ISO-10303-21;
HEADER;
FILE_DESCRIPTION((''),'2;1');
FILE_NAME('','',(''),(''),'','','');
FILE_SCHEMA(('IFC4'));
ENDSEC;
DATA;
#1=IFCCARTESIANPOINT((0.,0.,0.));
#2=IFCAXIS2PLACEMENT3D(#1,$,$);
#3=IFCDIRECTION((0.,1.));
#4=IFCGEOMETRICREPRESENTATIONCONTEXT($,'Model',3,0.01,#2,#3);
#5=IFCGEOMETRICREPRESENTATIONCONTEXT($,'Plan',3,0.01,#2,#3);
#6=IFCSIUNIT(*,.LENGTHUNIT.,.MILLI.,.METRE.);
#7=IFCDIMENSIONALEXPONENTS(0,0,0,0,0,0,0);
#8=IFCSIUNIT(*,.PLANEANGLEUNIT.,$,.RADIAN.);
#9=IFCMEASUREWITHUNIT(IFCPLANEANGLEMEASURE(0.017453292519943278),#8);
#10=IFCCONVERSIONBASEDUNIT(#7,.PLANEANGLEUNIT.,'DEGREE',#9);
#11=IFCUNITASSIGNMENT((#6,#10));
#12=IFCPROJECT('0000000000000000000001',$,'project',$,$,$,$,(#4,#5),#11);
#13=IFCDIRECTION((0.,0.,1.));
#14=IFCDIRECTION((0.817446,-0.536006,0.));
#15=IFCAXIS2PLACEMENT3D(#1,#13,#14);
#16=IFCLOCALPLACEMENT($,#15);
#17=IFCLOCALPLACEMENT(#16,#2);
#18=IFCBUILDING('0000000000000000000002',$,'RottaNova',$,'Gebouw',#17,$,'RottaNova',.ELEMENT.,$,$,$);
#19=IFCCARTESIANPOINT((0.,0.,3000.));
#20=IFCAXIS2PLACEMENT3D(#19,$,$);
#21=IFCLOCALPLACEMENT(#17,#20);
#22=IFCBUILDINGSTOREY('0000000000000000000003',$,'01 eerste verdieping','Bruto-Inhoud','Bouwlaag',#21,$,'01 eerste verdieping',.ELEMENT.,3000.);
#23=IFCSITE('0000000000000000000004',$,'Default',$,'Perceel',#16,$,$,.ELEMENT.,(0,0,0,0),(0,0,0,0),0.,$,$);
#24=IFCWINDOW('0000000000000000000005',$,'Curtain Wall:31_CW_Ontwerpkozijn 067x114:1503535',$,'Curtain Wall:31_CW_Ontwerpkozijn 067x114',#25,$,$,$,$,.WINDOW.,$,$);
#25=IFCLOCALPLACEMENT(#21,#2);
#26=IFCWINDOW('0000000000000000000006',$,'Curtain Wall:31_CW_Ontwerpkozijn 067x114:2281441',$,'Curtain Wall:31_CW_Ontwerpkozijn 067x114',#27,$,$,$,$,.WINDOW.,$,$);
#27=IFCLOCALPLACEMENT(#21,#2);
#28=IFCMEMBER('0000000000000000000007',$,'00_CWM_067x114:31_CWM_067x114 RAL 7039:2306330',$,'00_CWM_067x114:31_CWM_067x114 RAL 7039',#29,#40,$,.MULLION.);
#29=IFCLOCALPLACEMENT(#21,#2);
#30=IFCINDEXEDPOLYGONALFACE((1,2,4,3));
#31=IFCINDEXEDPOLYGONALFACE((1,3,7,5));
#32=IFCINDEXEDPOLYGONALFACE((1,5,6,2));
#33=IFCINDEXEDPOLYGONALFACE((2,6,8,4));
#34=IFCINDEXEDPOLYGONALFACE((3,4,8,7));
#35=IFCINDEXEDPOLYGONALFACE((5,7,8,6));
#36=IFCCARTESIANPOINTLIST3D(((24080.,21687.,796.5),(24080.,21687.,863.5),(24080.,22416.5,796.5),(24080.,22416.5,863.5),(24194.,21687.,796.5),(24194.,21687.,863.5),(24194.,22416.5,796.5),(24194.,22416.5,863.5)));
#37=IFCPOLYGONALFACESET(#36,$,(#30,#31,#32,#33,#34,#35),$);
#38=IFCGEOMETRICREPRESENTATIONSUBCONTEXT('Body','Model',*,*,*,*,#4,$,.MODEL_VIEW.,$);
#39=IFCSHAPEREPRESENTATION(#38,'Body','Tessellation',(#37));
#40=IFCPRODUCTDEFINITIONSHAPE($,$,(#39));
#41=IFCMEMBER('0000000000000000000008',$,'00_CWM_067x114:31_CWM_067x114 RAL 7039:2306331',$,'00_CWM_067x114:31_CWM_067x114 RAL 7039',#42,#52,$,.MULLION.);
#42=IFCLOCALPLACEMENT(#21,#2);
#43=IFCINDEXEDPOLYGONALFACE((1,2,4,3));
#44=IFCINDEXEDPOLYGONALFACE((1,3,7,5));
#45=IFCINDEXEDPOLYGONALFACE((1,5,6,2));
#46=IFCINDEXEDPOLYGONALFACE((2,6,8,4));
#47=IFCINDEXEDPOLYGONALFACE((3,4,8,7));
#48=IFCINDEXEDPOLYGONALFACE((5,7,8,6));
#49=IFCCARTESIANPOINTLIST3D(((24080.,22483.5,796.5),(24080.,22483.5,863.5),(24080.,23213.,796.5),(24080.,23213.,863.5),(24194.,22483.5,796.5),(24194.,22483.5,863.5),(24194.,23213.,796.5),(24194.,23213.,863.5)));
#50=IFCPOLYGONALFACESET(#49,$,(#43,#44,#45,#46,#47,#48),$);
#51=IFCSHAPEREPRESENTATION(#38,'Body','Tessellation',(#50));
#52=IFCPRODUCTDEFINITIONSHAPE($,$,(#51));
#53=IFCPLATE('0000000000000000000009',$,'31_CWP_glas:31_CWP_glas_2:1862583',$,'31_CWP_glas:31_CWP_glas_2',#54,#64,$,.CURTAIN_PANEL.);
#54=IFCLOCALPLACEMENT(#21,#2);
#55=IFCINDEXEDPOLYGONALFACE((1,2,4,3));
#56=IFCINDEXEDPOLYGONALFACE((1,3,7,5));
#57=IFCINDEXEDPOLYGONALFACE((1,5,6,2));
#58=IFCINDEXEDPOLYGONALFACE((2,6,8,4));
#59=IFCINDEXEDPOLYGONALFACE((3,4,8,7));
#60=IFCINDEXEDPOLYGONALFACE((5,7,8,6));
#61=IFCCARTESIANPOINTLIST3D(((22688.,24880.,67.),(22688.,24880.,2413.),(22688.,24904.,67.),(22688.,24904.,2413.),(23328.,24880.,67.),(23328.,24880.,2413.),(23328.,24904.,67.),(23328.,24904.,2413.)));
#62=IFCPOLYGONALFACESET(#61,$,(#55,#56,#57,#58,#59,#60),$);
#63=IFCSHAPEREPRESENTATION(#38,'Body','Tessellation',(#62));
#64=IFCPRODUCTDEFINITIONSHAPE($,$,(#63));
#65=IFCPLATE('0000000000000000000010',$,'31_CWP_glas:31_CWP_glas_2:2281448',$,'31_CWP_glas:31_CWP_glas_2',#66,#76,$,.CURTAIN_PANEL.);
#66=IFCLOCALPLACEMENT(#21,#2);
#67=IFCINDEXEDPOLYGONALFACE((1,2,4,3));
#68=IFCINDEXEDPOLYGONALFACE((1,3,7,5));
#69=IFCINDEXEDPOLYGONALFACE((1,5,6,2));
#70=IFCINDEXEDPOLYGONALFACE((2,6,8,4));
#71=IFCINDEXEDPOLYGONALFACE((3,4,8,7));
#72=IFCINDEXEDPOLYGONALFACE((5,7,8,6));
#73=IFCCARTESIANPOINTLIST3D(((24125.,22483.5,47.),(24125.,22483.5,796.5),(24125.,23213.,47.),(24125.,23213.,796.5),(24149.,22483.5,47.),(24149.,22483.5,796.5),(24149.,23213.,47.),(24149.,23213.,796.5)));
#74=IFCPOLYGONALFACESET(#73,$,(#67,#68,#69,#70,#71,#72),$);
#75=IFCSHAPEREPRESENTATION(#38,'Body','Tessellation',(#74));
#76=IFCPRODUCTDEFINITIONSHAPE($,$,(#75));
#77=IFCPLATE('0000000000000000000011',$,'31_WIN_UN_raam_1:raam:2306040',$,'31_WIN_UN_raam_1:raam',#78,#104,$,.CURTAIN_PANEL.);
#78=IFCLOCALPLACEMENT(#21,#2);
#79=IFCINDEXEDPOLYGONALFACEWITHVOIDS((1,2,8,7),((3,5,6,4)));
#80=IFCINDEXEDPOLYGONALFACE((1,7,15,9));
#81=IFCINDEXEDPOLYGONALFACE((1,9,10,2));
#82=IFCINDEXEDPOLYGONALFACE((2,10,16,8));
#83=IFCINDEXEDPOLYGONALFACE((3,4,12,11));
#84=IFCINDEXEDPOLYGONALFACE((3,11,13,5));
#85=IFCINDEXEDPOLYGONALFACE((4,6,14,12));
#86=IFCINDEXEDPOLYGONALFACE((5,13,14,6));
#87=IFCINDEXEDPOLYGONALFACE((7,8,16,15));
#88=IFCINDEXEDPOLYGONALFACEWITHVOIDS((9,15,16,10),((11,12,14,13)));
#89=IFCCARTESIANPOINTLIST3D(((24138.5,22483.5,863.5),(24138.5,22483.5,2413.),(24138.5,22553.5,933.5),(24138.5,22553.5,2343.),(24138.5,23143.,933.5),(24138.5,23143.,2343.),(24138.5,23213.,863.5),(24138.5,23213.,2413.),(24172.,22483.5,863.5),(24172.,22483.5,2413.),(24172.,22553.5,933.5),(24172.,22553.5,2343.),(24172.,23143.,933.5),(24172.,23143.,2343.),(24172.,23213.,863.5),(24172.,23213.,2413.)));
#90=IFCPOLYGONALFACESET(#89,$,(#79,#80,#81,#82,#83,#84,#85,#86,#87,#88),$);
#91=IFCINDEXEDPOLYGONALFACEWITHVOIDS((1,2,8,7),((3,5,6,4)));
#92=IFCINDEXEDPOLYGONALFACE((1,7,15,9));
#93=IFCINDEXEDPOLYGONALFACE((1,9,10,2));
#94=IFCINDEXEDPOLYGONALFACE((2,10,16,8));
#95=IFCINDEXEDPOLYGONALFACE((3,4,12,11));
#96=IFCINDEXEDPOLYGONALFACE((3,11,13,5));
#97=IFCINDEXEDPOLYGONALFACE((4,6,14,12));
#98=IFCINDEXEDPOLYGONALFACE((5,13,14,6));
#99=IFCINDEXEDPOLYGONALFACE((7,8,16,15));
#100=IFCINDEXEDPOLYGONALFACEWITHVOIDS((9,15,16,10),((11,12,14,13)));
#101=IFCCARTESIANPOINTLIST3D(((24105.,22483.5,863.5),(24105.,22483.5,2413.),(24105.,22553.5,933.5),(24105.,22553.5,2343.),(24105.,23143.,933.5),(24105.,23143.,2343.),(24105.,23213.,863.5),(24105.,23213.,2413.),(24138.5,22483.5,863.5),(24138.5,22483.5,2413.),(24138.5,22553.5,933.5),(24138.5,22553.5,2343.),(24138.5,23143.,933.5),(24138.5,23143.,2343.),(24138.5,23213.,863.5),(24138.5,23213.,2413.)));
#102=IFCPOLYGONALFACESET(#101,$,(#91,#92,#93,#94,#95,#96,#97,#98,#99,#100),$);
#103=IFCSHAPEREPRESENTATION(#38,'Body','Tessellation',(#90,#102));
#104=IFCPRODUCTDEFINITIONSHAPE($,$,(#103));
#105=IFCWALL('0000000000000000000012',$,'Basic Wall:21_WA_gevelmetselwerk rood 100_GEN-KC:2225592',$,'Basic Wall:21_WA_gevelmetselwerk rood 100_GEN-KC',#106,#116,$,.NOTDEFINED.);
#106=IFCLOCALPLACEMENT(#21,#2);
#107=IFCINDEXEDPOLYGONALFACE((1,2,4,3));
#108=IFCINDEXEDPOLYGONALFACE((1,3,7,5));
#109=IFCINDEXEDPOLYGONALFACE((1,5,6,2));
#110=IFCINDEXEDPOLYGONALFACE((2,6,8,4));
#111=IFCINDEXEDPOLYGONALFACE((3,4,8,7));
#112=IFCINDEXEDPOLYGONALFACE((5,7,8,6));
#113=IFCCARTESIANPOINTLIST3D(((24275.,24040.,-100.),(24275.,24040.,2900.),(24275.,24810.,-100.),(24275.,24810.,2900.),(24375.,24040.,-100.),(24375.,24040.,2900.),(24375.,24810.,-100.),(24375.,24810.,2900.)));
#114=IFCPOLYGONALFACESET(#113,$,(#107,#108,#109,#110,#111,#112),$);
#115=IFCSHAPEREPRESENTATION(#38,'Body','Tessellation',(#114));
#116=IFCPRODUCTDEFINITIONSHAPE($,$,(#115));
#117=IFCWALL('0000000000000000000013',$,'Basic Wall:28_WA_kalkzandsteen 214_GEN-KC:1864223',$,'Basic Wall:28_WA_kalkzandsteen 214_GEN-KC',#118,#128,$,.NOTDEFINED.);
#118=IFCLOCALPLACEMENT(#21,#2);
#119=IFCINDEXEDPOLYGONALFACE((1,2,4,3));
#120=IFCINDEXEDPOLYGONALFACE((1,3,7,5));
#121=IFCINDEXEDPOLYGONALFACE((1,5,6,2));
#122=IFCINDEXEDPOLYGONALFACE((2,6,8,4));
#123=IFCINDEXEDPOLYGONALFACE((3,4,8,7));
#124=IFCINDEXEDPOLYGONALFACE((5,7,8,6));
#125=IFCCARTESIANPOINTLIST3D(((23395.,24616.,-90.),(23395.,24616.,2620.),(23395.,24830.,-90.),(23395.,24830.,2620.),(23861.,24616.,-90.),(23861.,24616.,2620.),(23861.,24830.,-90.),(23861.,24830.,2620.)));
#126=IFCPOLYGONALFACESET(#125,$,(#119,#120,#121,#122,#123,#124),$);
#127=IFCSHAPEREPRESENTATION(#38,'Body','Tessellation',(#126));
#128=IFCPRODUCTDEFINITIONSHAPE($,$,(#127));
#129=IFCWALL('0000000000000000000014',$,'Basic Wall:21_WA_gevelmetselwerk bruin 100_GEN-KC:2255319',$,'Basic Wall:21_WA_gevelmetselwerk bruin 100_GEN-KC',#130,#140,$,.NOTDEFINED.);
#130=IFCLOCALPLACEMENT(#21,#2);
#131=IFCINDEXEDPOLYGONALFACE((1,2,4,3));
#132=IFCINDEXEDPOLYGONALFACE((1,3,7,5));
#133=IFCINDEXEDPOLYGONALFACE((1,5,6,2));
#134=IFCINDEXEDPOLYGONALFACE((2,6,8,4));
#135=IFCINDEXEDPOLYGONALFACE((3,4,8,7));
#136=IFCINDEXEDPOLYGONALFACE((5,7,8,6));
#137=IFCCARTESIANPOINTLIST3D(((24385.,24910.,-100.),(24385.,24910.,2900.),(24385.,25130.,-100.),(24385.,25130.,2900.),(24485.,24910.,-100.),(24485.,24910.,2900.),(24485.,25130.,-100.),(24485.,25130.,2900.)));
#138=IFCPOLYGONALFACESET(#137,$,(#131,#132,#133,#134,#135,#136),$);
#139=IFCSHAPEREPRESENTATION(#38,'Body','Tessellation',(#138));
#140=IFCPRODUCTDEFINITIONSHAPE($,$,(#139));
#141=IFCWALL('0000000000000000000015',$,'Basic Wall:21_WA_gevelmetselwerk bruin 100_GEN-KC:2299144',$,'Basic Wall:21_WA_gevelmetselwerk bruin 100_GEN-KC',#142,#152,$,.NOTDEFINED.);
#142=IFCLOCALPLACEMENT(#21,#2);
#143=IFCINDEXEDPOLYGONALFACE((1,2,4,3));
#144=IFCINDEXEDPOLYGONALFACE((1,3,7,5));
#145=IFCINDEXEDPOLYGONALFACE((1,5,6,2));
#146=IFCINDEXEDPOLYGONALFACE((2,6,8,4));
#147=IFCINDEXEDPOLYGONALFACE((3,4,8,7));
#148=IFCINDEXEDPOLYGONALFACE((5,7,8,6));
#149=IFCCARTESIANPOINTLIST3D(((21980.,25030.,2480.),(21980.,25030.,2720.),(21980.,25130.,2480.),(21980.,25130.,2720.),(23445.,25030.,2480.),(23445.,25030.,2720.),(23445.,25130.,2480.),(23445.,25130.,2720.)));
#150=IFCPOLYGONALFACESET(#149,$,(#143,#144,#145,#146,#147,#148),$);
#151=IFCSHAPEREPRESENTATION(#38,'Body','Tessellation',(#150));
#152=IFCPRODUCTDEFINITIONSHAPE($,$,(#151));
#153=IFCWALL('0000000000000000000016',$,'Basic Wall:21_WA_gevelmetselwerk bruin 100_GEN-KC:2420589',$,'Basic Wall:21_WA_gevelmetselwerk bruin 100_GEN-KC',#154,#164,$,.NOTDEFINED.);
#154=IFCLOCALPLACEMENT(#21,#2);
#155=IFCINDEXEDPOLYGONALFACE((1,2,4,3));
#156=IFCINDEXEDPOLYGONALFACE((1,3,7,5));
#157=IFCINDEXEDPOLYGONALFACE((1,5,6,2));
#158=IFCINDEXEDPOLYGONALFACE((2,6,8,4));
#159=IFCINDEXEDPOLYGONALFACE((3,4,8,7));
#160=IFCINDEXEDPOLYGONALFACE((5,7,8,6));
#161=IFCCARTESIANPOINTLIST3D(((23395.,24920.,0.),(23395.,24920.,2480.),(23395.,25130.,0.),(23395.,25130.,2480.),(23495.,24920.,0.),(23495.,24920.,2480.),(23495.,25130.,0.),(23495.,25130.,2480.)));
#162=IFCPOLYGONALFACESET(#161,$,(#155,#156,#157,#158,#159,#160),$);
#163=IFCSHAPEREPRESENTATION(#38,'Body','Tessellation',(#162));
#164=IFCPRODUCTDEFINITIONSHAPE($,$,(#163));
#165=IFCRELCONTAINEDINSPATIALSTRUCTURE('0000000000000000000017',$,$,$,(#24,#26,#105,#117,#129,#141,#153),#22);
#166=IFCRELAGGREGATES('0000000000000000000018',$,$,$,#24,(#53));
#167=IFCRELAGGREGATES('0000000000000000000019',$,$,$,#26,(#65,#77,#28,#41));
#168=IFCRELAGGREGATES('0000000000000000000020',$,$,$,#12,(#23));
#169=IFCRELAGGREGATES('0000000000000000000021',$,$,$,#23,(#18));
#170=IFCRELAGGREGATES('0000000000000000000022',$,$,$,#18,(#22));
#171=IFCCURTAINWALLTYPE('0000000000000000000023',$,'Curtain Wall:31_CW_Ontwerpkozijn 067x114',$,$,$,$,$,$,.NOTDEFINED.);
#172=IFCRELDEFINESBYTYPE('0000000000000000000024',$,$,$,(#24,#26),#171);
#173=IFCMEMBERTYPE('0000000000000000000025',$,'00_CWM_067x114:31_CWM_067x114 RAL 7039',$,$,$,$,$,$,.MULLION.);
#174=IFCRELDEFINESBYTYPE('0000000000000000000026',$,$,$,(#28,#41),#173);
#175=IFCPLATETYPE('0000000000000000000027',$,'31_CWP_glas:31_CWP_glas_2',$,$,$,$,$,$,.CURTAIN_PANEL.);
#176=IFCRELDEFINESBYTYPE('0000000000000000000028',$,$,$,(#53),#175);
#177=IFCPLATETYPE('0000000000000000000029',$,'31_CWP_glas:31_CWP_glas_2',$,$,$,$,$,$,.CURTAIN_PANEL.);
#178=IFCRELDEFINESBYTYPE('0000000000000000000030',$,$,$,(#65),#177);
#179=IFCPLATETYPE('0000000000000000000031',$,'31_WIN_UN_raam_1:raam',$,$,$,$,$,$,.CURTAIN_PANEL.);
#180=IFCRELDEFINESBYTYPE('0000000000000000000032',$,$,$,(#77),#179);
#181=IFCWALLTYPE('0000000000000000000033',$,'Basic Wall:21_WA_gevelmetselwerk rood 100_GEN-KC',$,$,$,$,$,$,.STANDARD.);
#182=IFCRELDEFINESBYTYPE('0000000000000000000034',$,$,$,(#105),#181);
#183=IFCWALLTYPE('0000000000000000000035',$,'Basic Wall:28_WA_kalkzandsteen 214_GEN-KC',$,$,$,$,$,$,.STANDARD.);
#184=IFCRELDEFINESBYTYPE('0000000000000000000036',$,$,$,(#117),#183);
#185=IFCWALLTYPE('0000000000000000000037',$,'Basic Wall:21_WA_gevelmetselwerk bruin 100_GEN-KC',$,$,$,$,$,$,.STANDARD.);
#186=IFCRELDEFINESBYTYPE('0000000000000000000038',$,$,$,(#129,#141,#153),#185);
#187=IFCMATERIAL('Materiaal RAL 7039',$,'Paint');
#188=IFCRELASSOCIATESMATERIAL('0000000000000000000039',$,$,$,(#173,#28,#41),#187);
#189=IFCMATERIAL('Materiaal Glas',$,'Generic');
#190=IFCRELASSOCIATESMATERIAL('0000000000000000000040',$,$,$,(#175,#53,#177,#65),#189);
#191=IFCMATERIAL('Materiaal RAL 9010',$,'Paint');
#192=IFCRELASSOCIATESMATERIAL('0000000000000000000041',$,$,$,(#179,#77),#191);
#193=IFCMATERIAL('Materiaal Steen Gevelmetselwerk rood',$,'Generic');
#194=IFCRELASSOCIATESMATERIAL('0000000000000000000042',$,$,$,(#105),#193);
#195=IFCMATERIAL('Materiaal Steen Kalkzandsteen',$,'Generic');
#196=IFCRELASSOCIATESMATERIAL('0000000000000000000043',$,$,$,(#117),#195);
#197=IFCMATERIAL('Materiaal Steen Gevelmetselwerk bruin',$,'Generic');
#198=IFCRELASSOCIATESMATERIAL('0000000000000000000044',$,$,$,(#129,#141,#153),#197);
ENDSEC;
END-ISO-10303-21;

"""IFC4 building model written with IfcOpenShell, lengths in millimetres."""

from ifc_helpers import new_model, entity, si_unit, converted_unit, direction, frame, origin, place, context, subcontext, project, spatial, indexed_curve, outline, extrude, source, transform, mapped, material, type_object, type_shapes, element, aggregate, save


model = new_model("IFC4")

# Units and contexts
model_context = context("Model", 3, precision=0.01, world=origin(), true_north=direction((0.0, 1.0)))
plan_context = context("Plan", 3, precision=0.01, world=origin(), true_north=direction((0.0, 1.0)))
body_context = subcontext(model_context, "Body", "Model", "MODEL_VIEW")
ifc_project = project(units=[si_unit("LENGTHUNIT", "METRE", prefix="MILLI"), converted_unit("PLANEANGLEUNIT", "DEGREE", entity("IfcPlaneAngleMeasure", 0.017453292519943278), si_unit("PLANEANGLEUNIT", "RADIAN"), dimensions=[0, 0, 0, 0, 0, 0, 0])], contexts=[model_context, plan_context])

# Site, building, storey
site_placement = place(None, frame((0.0, 0.0, 0.0), z_axis=(0.0, 0.0, 1.0), x_axis=(0.817446, -0.536006, 0.0)))
site = spatial("IfcSite", under=ifc_project, at=site_placement, Name="Default", ObjectType="Perceel", CompositionType="ELEMENT", RefLatitude=(0, 0, 0, 0), RefLongitude=(0, 0, 0, 0), RefElevation=0.0)
building_placement = place(site_placement, origin())
building = spatial("IfcBuilding", under=site, at=building_placement, Name="RottaNova", ObjectType="Gebouw", LongName="RottaNova", CompositionType="ELEMENT")
storey_placement = place(building_placement, frame((0.0, 0.0, 3000.0)))
storey = spatial("IfcBuildingStorey", under=building, at=storey_placement, Name="01 eerste verdieping", Description="Bruto-Inhoud", ObjectType="Bouwlaag", LongName="01 eerste verdieping", CompositionType="ELEMENT", Elevation=3000.0)

# Windows, members
curtain_wall_type = type_object("IfcCurtainWallType", Name="Curtain Wall:31_CW_Ontwerpkozijn 067x114", PredefinedType="NOTDEFINED")
window_1_placement = place(storey_placement, frame((0.0, 0.0, -3000.0)))
window_1 = element("IfcWindow", 1, at=window_1_placement, inside=storey, type_object=curtain_wall_type, Name="Curtain Wall:31_CW_Ontwerpkozijn 067x114:1503535", ObjectType="Curtain Wall:31_CW_Ontwerpkozijn 067x114", PredefinedType="WINDOW")
ifc_material_1 = material(Name="Materiaal RAL 7039", Category="Paint")
window_2_placement = place(storey_placement, frame((0.0, 0.0, -3000.0)))
window_2 = element("IfcWindow", 2, at=window_2_placement, inside=storey, type_object=curtain_wall_type, Name="Curtain Wall:31_CW_Ontwerpkozijn 067x114:2281441", ObjectType="Curtain Wall:31_CW_Ontwerpkozijn 067x114", PredefinedType="WINDOW")
member_type_1 = type_object("IfcMemberType", Name="00_CWM_067x114:31_CWM_067x114 RAL 7039", PredefinedType="MULLION", material=ifc_material_1)
shared_shape_1 = source(origin(), body_context, "Body", "SweptSolid", [
    extrude(outline(indexed_curve([(-33.5, -57.0), (33.5, -57.0), (33.5, 57.0), (-33.5, 57.0), (-33.5, -57.0)], self_intersect=False)), frame((0.0, 57.0, -729.5), z_axis=(0.0, 0.0, 1.0), x_axis=(-1.0, 0.0, 0.0)), (0.0, 0.0, 1.0), 729.5),
])
type_shapes(member_type_1, [shared_shape_1])
member_1_placement = place(window_2_placement, frame((24080.0, 22416.5, 3830.0), z_axis=(0.0, 1.0, 0.0), x_axis=(0.0, 0.0, 1.0)))
member_1 = element("IfcMember", 3, at=member_1_placement, type_object=member_type_1, material=ifc_material_1, Name="00_CWM_067x114:31_CWM_067x114 RAL 7039:2306330", ObjectType="00_CWM_067x114:31_CWM_067x114 RAL 7039", PredefinedType="MULLION", context=body_context, shape_type="MappedRepresentation", body=[
    mapped(shared_shape_1, transform((0.0, 0.0, 0.0), scale=1.0)),
])
member_2_placement = place(window_2_placement, frame((24080.0, 23213.0, 3830.0), z_axis=(0.0, 1.0, 0.0), x_axis=(0.0, 0.0, 1.0)))
member_2 = element("IfcMember", 4, at=member_2_placement, type_object=member_type_1, material=ifc_material_1, Name="00_CWM_067x114:31_CWM_067x114 RAL 7039:2306331", ObjectType="00_CWM_067x114:31_CWM_067x114 RAL 7039", PredefinedType="MULLION", context=body_context, shape_type="MappedRepresentation", body=[
    mapped(shared_shape_1, transform((0.0, 0.0, 0.0), scale=1.0)),
])

# Plates
ifc_material_2 = material(Name="Materiaal Glas", Category="Generic")
plate_type_1 = type_object("IfcPlateType", Name="31_CWP_glas:31_CWP_glas_2", PredefinedType="CURTAIN_PANEL", material=ifc_material_2)
shared_shape_2 = source(origin(), body_context, "Body", "SweptSolid", [
    extrude(outline(indexed_curve([(-12.0, -320.0), (12.0, -320.0), (12.0, 320.0), (-12.0, 320.0), (-12.0, -320.0)], self_intersect=False)), frame((0.0, 57.0, 0.0), z_axis=(0.0, 0.0, 1.0), x_axis=(0.0, 1.0, 0.0)), (0.0, 0.0, 1.0), 2346.0),
])
type_shapes(plate_type_1, [shared_shape_2])
plate_1_placement = place(window_1_placement, frame((23008.0, 24835.0, 3067.0)))
plate_1 = element("IfcPlate", 5, at=plate_1_placement, type_object=plate_type_1, material=ifc_material_2, Name="31_CWP_glas:31_CWP_glas_2:1862583", ObjectType="31_CWP_glas:31_CWP_glas_2", PredefinedType="CURTAIN_PANEL", context=body_context, shape_type="MappedRepresentation", body=[
    mapped(shared_shape_2, transform((0.0, 0.0, 0.0), scale=1.0)),
])
aggregate(window_1, [plate_1])
plate_type_2 = type_object("IfcPlateType", Name="31_CWP_glas:31_CWP_glas_2", PredefinedType="CURTAIN_PANEL", material=ifc_material_2)
shared_shape_3 = source(origin(), body_context, "Body", "SweptSolid", [
    extrude(outline(indexed_curve([(-12.0, -364.7), (12.0, -364.7), (12.0, 364.7), (-12.0, 364.7), (-12.0, -364.7)], self_intersect=False)), frame((0.0, -57.0, 0.0), z_axis=(0.0, 0.0, 1.0), x_axis=(0.0, 1.0, 0.0)), (0.0, 0.0, 1.0), 749.5),
])
type_shapes(plate_type_2, [shared_shape_3])
plate_2_placement = place(window_2_placement, frame((24080.0, 22848.2, 3047.0), z_axis=(0.0, 0.0, 1.0), x_axis=(0.0, 1.0, 0.0)))
plate_2 = element("IfcPlate", 6, at=plate_2_placement, type_object=plate_type_2, material=ifc_material_2, Name="31_CWP_glas:31_CWP_glas_2:2281448", ObjectType="31_CWP_glas:31_CWP_glas_2", PredefinedType="CURTAIN_PANEL", context=body_context, shape_type="MappedRepresentation", body=[
    mapped(shared_shape_3, transform((0.0, 0.0, 0.0), scale=1.0)),
])
ifc_material_3 = material(Name="Materiaal RAL 9010", Category="Paint")
plate_type_3 = type_object("IfcPlateType", Name="31_WIN_UN_raam_1:raam", PredefinedType="CURTAIN_PANEL", material=ifc_material_3)
shared_shape_4 = source(origin(), body_context, "Body", "SweptSolid", [
    extrude(outline(indexed_curve([(-364.7, -774.7), (364.7, -774.7), (364.7, 774.7), (-364.7, 774.7), (-364.7, -774.7)], self_intersect=False), holes=[indexed_curve([(-294.7, 704.7), (294.7, 704.7), (294.7, -704.8), (-294.7, -704.8), (-294.7, 704.7)], self_intersect=False)]), frame((0.0, -92.0, 774.8), z_axis=(0.0, 1.0, 0.0), x_axis=(1.0, 0.0, 0.0)), (0.0, 0.0, 1.0), 33.5),
    extrude(outline(indexed_curve([(-364.7, -774.7), (364.7, -774.7), (364.7, 774.7), (-364.7, 774.7), (-364.7, -774.7)], self_intersect=False), holes=[indexed_curve([(-294.7, 704.7), (294.7, 704.7), (294.7, -704.8), (-294.7, -704.8), (-294.7, 704.7)], self_intersect=False)]), frame((0.0, -58.5, 774.8), z_axis=(0.0, 1.0, 0.0), x_axis=(1.0, 0.0, 0.0)), (0.0, 0.0, 1.0), 33.5),
])
type_shapes(plate_type_3, [shared_shape_4])
plate_3_placement = place(window_2_placement, frame((24080.0, 22848.2, 3863.5), z_axis=(0.0, 0.0, 1.0), x_axis=(0.0, 1.0, 0.0)))
plate_3 = element("IfcPlate", 7, at=plate_3_placement, type_object=plate_type_3, material=ifc_material_3, Name="31_WIN_UN_raam_1:raam:2306040", ObjectType="31_WIN_UN_raam_1:raam", PredefinedType="CURTAIN_PANEL", context=body_context, shape_type="MappedRepresentation", body=[
    mapped(shared_shape_4, transform((0.0, 0.0, 0.0), scale=1.0)),
])
aggregate(window_2, [plate_2, plate_3, member_1, member_2])

# Walls
ifc_material_4 = material(Name="Materiaal Steen Gevelmetselwerk rood", Category="Generic")
wall_type_1 = type_object("IfcWallType", Name="Basic Wall:21_WA_gevelmetselwerk rood 100_GEN-KC", PredefinedType="STANDARD")
wall_1_placement = place(storey_placement, frame((24325.0, 24810.0, -100.0), z_axis=(0.0, 0.0, 1.0), x_axis=(0.0, -1.0, 0.0)))
element("IfcWall", 8, at=wall_1_placement, inside=storey, type_object=wall_type_1, material=ifc_material_4, Name="Basic Wall:21_WA_gevelmetselwerk rood 100_GEN-KC:2225592", ObjectType="Basic Wall:21_WA_gevelmetselwerk rood 100_GEN-KC", PredefinedType="NOTDEFINED", context=body_context, shape_type="SweptSolid", body=[
    extrude(outline(indexed_curve([(770.0, 50.0), (0.0, 50.0), (0.0, -50.0), (770.0, -50.0), (770.0, 50.0)], self_intersect=False)), origin(), (0.0, 0.0, 1.0), 3000.0),
])
ifc_material_5 = material(Name="Materiaal Steen Kalkzandsteen", Category="Generic")
wall_type_2 = type_object("IfcWallType", Name="Basic Wall:28_WA_kalkzandsteen 214_GEN-KC", PredefinedType="STANDARD")
wall_2_placement = place(storey_placement, frame((23395.0, 24723.0, -90.0)))
element("IfcWall", 9, at=wall_2_placement, inside=storey, type_object=wall_type_2, material=ifc_material_5, Name="Basic Wall:28_WA_kalkzandsteen 214_GEN-KC:1864223", ObjectType="Basic Wall:28_WA_kalkzandsteen 214_GEN-KC", PredefinedType="NOTDEFINED", context=body_context, shape_type="SweptSolid", body=[
    extrude(outline(indexed_curve([(466.0, 107.0), (0.0, 107.0), (0.0, -107.0), (466.0, -107.0), (466.0, 107.0)], self_intersect=False)), origin(), (0.0, 0.0, 1.0), 2710.0),
])
ifc_material_6 = material(Name="Materiaal Steen Gevelmetselwerk bruin", Category="Generic")
wall_type_3 = type_object("IfcWallType", Name="Basic Wall:21_WA_gevelmetselwerk bruin 100_GEN-KC", PredefinedType="STANDARD")
wall_3_placement = place(storey_placement, frame((24435.0, 25130.0, -100.0), z_axis=(0.0, 0.0, 1.0), x_axis=(0.0, -1.0, 0.0)))
element("IfcWall", 10, at=wall_3_placement, inside=storey, type_object=wall_type_3, material=ifc_material_6, Name="Basic Wall:21_WA_gevelmetselwerk bruin 100_GEN-KC:2255319", ObjectType="Basic Wall:21_WA_gevelmetselwerk bruin 100_GEN-KC", PredefinedType="NOTDEFINED", context=body_context, shape_type="SweptSolid", body=[
    extrude(outline(indexed_curve([(220.0, 50.0), (0.0, 50.0), (0.0, -50.0), (220.0, -50.0), (220.0, 50.0)], self_intersect=False)), origin(), (0.0, 0.0, 1.0), 3000.0),
])
wall_4_placement = place(storey_placement, frame((23445.0, 25080.0, 2480.0), z_axis=(0.0, 0.0, 1.0), x_axis=(-1.0, 0.0, 0.0)))
element("IfcWall", 11, at=wall_4_placement, inside=storey, type_object=wall_type_3, material=ifc_material_6, Name="Basic Wall:21_WA_gevelmetselwerk bruin 100_GEN-KC:2299144", ObjectType="Basic Wall:21_WA_gevelmetselwerk bruin 100_GEN-KC", PredefinedType="NOTDEFINED", context=body_context, shape_type="SweptSolid", body=[
    extrude(outline(indexed_curve([(1465.0, 50.0), (0.0, 50.0), (0.0, -50.0), (1465.0, -50.0), (1465.0, 50.0)], self_intersect=False)), origin(), (0.0, 0.0, 1.0), 240.0),
])
wall_5_placement = place(storey_placement, frame((23445.0, 24920.0, 0.0), z_axis=(0.0, 0.0, 1.0), x_axis=(0.0, 1.0, 0.0)))
element("IfcWall", 12, at=wall_5_placement, inside=storey, type_object=wall_type_3, material=ifc_material_6, Name="Basic Wall:21_WA_gevelmetselwerk bruin 100_GEN-KC:2420589", ObjectType="Basic Wall:21_WA_gevelmetselwerk bruin 100_GEN-KC", PredefinedType="NOTDEFINED", context=body_context, shape_type="SweptSolid", body=[
    extrude(outline(indexed_curve([(210.0, 50.0), (0.0, 50.0), (0.0, -50.0), (210.0, -50.0), (210.0, 50.0)], self_intersect=False)), origin(), (0.0, 0.0, 1.0), 2480.0),
])

save(model, "model.ifc")
